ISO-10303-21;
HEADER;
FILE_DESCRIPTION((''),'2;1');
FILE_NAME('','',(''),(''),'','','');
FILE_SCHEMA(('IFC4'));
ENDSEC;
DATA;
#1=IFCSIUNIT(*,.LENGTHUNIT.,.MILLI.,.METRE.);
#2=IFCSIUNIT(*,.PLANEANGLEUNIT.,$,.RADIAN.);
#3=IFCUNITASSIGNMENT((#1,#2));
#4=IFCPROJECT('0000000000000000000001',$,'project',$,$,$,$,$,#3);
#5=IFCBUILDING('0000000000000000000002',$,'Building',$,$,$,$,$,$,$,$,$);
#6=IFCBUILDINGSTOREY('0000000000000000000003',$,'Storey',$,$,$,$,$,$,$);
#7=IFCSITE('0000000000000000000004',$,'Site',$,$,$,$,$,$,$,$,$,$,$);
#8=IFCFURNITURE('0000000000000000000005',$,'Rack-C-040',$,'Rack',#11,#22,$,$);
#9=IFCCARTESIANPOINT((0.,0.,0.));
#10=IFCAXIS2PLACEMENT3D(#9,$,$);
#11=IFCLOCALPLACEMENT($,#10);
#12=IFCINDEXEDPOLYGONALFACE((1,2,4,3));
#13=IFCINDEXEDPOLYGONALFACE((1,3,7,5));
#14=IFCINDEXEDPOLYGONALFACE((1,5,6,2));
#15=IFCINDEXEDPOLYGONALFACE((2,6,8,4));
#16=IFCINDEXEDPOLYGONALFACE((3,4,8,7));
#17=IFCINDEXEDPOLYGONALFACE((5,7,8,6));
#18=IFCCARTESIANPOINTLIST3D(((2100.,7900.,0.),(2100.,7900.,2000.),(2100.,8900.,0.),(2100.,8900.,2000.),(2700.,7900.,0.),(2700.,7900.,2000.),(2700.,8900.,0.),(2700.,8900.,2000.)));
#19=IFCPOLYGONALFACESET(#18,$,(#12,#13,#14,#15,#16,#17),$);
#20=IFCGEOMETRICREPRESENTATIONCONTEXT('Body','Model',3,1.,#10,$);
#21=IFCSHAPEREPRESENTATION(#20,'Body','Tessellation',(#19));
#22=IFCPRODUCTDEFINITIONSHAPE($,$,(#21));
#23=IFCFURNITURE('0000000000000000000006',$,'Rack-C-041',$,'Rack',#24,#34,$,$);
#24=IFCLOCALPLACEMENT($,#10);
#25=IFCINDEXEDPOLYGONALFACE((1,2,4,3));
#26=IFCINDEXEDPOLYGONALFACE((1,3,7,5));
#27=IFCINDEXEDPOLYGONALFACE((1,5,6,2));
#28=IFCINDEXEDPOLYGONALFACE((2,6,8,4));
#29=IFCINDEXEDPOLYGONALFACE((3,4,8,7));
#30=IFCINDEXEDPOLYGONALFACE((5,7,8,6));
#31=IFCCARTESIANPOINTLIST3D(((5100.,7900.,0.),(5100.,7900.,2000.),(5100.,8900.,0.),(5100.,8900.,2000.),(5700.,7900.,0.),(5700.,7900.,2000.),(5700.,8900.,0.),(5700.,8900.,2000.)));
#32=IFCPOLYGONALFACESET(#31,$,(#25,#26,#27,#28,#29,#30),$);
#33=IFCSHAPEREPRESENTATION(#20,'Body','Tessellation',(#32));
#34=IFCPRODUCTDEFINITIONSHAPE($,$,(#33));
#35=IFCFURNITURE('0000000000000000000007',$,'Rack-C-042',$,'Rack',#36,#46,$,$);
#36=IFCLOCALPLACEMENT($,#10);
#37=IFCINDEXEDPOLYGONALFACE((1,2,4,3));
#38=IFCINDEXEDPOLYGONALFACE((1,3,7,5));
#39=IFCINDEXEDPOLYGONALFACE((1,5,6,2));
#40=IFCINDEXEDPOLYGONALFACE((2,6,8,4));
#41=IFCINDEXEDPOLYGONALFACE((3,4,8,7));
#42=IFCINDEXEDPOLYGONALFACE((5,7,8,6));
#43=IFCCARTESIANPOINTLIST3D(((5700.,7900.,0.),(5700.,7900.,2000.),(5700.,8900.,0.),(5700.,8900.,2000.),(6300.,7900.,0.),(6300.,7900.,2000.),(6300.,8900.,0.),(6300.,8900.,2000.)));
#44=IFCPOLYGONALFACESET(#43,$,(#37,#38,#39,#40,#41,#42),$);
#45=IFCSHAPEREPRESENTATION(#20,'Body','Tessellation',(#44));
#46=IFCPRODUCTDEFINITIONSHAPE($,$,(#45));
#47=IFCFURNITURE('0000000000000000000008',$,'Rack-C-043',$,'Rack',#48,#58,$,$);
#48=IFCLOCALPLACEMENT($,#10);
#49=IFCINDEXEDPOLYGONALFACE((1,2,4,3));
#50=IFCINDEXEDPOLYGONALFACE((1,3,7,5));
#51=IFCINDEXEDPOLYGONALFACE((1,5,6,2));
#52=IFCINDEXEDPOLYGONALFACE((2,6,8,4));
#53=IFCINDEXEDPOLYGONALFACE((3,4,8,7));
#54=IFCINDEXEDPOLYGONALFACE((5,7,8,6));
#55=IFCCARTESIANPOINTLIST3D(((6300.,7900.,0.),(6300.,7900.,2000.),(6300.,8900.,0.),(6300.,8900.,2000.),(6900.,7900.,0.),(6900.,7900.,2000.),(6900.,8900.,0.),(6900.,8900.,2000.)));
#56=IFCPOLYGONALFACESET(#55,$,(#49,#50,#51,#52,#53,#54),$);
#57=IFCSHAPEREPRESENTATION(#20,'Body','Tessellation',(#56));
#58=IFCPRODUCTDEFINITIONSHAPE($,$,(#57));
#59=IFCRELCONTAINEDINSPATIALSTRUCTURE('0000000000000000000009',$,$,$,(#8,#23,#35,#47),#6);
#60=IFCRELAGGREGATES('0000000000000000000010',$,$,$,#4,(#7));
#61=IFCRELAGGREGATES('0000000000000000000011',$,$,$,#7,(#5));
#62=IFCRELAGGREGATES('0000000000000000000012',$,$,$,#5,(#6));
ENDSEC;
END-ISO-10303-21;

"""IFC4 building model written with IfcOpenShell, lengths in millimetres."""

from ifc_helpers import new_model, si_unit, frame, origin, place, context, project, spatial, rectangle, extrude, element, save


model = new_model("IFC4")

# Units and contexts
model_context = context("Model", 3, precision=1.0, world=origin(), identifier="Body")
ifc_project = project(units=[si_unit("LENGTHUNIT", "METRE", prefix="MILLI"), si_unit("PLANEANGLEUNIT", "RADIAN")])

# Site, building, storey
site = spatial("IfcSite", under=ifc_project, Name="Site")
building = spatial("IfcBuilding", under=site, Name="Building")
storey = spatial("IfcBuildingStorey", under=building, Name="Storey")

# Furniture
for number, where, z_axis, x_axis, name in (
    (1, (2400.0, 8400.0, 0.0), (0.0, 0.0, 1.0), (1.0, 0.0, 0.0), "Rack-C-040"),
    (2, (5400.0, 8400.0, 0.0), (0.0, 0.0, 1.0), (1.0, 0.0, 0.0), "Rack-C-041"),
    (3, (6000.0, 8400.0, 0.0), (0.0, 0.0, 1.0), (1.0, 0.0, 0.0), "Rack-C-042"),
    (4, (6600.0, 8400.0, 0.0), (0.0, 0.0, 1.0), (1.0, 0.0, 0.0), "Rack-C-043"),
):
    element("IfcFurniture", number, at=place(None, frame(where, z_axis=z_axis, x_axis=x_axis)), inside=storey, Name=name, ObjectType="Rack", context=model_context, shape_type="SweptSolid", body=[
        extrude(rectangle(XDim=600.0, YDim=1000.0), origin(), (0.0, 0.0, 1.0), 2000.0),
    ])

save(model, "model.ifc")
